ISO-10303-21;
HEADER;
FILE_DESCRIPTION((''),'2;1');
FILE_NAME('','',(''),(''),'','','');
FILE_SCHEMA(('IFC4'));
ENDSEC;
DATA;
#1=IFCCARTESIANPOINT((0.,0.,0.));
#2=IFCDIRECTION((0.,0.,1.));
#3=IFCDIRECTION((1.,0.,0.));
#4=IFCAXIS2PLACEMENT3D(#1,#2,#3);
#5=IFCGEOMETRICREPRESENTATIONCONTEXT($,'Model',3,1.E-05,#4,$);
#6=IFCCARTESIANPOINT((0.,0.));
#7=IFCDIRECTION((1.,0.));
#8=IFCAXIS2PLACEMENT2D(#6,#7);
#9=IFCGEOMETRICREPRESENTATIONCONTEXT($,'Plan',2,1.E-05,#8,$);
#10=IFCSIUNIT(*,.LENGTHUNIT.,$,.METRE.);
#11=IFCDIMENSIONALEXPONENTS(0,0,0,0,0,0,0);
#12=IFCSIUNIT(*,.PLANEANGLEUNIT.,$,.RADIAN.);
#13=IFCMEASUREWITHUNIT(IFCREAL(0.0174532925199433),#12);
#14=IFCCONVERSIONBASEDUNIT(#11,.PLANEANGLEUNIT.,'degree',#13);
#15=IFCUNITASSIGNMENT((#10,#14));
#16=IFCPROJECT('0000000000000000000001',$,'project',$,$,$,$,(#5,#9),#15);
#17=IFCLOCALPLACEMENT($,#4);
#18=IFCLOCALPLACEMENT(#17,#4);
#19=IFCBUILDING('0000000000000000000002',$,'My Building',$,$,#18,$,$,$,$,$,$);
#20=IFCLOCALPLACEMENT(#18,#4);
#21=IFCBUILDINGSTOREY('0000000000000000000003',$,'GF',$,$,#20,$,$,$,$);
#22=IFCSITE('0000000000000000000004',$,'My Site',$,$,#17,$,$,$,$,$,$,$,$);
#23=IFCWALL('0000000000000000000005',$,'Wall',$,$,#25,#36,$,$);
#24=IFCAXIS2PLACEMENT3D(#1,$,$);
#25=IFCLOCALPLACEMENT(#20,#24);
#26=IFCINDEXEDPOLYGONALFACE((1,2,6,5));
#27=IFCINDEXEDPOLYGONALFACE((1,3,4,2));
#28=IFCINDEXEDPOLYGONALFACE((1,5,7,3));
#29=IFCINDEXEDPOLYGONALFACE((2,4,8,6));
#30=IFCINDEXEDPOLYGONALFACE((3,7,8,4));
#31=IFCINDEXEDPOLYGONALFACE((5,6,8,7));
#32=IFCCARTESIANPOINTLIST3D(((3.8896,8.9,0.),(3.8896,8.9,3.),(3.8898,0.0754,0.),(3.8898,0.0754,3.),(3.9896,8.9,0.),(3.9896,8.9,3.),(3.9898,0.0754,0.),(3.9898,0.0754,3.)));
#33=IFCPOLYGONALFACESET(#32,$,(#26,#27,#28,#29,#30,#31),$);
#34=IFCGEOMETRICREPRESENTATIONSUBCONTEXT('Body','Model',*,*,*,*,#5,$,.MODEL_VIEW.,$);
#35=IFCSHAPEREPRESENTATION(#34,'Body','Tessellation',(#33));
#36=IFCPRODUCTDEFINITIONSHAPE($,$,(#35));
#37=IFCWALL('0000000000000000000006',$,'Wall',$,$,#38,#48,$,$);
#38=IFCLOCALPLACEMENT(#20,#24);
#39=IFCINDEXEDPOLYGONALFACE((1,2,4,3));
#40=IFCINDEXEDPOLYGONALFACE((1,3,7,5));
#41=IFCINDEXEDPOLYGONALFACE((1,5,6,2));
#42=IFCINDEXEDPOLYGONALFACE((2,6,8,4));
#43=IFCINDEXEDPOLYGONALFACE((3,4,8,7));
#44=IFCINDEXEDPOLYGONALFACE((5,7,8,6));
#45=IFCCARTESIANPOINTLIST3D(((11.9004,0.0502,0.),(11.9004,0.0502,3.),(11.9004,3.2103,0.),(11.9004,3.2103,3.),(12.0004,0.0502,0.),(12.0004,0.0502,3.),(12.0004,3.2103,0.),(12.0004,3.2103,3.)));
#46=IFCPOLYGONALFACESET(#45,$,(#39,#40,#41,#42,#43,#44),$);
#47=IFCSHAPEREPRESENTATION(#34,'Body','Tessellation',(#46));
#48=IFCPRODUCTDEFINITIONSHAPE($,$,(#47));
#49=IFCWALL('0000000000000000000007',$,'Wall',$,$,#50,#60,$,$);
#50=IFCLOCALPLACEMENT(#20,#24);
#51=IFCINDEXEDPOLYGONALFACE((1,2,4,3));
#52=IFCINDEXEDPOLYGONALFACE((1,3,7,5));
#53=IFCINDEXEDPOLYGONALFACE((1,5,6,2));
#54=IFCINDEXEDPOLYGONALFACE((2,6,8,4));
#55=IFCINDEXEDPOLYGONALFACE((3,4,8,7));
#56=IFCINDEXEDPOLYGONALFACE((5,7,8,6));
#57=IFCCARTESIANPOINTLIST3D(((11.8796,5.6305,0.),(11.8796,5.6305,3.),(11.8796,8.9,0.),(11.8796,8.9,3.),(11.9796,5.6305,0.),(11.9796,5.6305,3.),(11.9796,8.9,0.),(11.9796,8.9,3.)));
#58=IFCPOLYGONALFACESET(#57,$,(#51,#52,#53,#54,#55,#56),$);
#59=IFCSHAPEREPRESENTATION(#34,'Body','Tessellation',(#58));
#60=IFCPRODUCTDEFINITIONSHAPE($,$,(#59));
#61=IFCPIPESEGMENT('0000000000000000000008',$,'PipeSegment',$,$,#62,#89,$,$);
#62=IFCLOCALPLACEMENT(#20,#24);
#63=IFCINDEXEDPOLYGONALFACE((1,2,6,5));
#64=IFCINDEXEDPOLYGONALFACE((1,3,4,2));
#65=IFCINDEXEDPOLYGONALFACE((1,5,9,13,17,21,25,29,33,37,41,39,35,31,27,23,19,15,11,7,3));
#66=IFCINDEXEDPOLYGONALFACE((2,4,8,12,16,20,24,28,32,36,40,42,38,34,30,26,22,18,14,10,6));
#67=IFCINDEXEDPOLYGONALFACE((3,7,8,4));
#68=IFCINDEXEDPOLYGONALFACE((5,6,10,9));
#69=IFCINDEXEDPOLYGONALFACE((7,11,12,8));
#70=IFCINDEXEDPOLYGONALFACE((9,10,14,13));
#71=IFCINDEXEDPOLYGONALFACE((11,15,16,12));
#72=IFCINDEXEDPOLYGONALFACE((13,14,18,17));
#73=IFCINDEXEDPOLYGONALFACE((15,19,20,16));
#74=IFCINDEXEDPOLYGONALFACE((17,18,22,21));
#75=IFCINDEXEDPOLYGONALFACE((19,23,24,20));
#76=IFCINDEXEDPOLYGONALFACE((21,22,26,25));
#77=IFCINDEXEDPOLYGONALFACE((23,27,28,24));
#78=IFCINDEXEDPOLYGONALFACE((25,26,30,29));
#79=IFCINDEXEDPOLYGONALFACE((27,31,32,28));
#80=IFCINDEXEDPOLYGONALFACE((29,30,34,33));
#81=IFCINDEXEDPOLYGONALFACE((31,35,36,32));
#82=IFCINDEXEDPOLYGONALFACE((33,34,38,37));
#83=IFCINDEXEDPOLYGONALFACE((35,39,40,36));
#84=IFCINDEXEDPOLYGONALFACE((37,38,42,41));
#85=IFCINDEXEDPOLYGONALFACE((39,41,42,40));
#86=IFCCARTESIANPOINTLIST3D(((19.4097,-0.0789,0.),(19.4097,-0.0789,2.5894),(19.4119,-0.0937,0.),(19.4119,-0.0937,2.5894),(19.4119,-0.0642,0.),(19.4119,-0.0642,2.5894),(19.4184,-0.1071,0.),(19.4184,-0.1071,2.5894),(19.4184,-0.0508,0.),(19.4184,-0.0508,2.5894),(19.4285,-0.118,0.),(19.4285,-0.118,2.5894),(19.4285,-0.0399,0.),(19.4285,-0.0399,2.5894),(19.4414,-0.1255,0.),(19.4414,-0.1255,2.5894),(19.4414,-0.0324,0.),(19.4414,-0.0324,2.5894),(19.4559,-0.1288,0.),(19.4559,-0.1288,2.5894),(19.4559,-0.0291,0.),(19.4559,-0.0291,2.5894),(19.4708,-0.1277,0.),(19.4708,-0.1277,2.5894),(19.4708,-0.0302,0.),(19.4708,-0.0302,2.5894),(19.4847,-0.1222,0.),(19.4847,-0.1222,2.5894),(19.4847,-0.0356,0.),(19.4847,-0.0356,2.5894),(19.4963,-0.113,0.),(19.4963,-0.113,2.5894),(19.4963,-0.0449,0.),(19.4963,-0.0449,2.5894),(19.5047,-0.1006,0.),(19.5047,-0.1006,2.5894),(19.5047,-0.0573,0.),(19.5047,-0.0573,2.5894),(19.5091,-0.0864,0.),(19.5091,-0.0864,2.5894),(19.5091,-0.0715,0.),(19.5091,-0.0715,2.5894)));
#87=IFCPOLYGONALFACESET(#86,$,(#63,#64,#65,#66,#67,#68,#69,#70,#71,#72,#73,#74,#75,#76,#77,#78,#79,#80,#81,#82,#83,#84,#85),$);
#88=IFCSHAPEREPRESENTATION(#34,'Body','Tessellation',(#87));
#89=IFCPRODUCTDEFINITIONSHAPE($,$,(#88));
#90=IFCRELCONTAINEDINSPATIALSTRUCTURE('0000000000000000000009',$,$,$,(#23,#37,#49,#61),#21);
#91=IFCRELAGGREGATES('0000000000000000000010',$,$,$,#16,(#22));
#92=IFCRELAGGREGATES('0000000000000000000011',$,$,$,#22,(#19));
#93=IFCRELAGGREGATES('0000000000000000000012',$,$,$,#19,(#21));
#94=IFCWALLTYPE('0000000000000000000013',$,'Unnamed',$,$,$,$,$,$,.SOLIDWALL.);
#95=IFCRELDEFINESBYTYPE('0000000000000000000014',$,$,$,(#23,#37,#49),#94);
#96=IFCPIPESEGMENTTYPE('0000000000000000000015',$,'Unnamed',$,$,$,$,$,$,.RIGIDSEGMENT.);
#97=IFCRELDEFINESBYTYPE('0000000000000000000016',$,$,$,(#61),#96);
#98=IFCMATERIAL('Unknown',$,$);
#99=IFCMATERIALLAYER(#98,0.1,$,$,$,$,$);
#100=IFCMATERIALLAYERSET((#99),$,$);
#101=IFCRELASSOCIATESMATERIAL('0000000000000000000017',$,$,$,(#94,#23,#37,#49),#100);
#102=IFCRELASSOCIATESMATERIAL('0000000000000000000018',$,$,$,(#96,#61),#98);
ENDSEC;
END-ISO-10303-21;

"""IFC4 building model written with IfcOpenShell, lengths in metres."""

from ifc_helpers import new_model, entity, si_unit, converted_unit, frame, origin_with_axes, origin_2d_with_axis, place, context, subcontext, project, spatial, line, indexed_curve, circle, outline, extrude, material, layer, layer_set, layer_usage, material_profile, profile_set, profile_usage, type_object, element, save


model = new_model("IFC4")

# Units and contexts
model_context = context("Model", 3, precision=1e-05, world=origin_with_axes())
plan_context = context("Plan", 2, precision=1e-05, world=origin_2d_with_axis())
body_context_1 = subcontext(model_context, "Body", "Model", "MODEL_VIEW")
ifc_project = project(units=[si_unit("LENGTHUNIT", "METRE"), converted_unit("PLANEANGLEUNIT", "degree", entity("IfcReal", 0.0174532925199433), si_unit("PLANEANGLEUNIT", "RADIAN"), dimensions=[0, 0, 0, 0, 0, 0, 0])], contexts=[model_context, plan_context])

# Site, building, storey
site_placement = place(None, origin_with_axes())
site = spatial("IfcSite", under=ifc_project, at=site_placement, Name="My Site")
building_placement = place(site_placement, origin_with_axes())
building = spatial("IfcBuilding", under=site, at=building_placement, Name="My Building")
storey_placement = place(building_placement, origin_with_axes())
storey = spatial("IfcBuildingStorey", under=building, at=storey_placement, Name="GF")

# Shared definitions
ifc_material = material(Name="Unknown")
ifc_layer = layer(ifc_material, 0.1)
ifc_layer_set = layer_set([ifc_layer])
wall_type = type_object("IfcWallType", Name="Unnamed", PredefinedType="SOLIDWALL", material=ifc_layer_set)

# Walls
ifc_layer_usage_1 = layer_usage(ifc_layer_set, "AXIS2", "POSITIVE", 0.0)
wall_1_placement = place(storey_placement, frame((3.9898, 0.0754, 0.0), z_axis=(0.0, 0.0, 1.0), x_axis=(-0.000021, 1.0, 0.0)))
element("IfcWall", 1, at=wall_1_placement, inside=storey, type_object=wall_type, material=ifc_layer_usage_1, Name="Wall", context=body_context_1, shape_type="SweptSolid", body=[
    extrude(outline(indexed_curve([(0.0, 0.0), (0.0, 0.1), (8.8246, 0.1), (8.8246, 0.0)], segments=[line(1, 2, 3, 4, 1)])), origin_with_axes(), (0.0, 0.0, 1.0), 3.0),
])
ifc_layer_usage_2 = layer_usage(ifc_layer_set, "AXIS2", "POSITIVE", 0.0)
wall_2_placement = place(storey_placement, frame((12.0004, 0.0502, 0.0), z_axis=(0.0, 0.0, 1.0), x_axis=(0.000013, 1.0, 0.0)))
element("IfcWall", 2, at=wall_2_placement, inside=storey, type_object=wall_type, material=ifc_layer_usage_2, Name="Wall", context=body_context_1, shape_type="SweptSolid", body=[
    extrude(outline(indexed_curve([(0.0, 0.0), (0.0, 0.1), (3.1602, 0.1), (3.1602, 0.0)], segments=[line(1, 2, 3, 4, 1)])), origin_with_axes(), (0.0, 0.0, 1.0), 3.0),
])
ifc_layer_usage_3 = layer_usage(ifc_layer_set, "AXIS2", "POSITIVE", 0.0)
wall_3_placement = place(storey_placement, frame((11.9796, 5.6305, 0.0), z_axis=(0.0, 0.0, 1.0), x_axis=(0.0, 1.0, 0.0)))
element("IfcWall", 3, at=wall_3_placement, inside=storey, type_object=wall_type, material=ifc_layer_usage_3, Name="Wall", context=body_context_1, shape_type="SweptSolid", body=[
    extrude(outline(indexed_curve([(0.0, 0.0), (0.0, 0.1), (3.2695, 0.1), (3.2695, 0.0)], segments=[line(1, 2, 3, 4, 1)])), origin_with_axes(), (0.0, 0.0, 1.0), 3.0),
])

# Pipe segment
ifc_material_profile = material_profile(ifc_material, circle(Radius=0.05))
ifc_profile_set = profile_set([ifc_material_profile])
ifc_profile_usage = profile_usage(ifc_profile_set, cardinal=5)
pipe_segment_type = type_object("IfcPipeSegmentType", Name="Unnamed", PredefinedType="RIGIDSEGMENT", material=ifc_profile_set)
pipe_segment_placement = place(storey_placement, frame((19.4597, -0.0789, 2.5894), z_axis=(0.0, 0.0, -1.0), x_axis=(-1.0, 0.0, 0.0)))
element("IfcPipeSegment", 4, at=pipe_segment_placement, inside=storey, type_object=pipe_segment_type, material=ifc_profile_usage, Name="PipeSegment", context=body_context_1, shape_type="SweptSolid", body=[
    extrude(circle(Radius=0.05), origin_with_axes(), (0.0, 0.0, 1.0), 2.5894),
])

save(model, "model.ifc")
